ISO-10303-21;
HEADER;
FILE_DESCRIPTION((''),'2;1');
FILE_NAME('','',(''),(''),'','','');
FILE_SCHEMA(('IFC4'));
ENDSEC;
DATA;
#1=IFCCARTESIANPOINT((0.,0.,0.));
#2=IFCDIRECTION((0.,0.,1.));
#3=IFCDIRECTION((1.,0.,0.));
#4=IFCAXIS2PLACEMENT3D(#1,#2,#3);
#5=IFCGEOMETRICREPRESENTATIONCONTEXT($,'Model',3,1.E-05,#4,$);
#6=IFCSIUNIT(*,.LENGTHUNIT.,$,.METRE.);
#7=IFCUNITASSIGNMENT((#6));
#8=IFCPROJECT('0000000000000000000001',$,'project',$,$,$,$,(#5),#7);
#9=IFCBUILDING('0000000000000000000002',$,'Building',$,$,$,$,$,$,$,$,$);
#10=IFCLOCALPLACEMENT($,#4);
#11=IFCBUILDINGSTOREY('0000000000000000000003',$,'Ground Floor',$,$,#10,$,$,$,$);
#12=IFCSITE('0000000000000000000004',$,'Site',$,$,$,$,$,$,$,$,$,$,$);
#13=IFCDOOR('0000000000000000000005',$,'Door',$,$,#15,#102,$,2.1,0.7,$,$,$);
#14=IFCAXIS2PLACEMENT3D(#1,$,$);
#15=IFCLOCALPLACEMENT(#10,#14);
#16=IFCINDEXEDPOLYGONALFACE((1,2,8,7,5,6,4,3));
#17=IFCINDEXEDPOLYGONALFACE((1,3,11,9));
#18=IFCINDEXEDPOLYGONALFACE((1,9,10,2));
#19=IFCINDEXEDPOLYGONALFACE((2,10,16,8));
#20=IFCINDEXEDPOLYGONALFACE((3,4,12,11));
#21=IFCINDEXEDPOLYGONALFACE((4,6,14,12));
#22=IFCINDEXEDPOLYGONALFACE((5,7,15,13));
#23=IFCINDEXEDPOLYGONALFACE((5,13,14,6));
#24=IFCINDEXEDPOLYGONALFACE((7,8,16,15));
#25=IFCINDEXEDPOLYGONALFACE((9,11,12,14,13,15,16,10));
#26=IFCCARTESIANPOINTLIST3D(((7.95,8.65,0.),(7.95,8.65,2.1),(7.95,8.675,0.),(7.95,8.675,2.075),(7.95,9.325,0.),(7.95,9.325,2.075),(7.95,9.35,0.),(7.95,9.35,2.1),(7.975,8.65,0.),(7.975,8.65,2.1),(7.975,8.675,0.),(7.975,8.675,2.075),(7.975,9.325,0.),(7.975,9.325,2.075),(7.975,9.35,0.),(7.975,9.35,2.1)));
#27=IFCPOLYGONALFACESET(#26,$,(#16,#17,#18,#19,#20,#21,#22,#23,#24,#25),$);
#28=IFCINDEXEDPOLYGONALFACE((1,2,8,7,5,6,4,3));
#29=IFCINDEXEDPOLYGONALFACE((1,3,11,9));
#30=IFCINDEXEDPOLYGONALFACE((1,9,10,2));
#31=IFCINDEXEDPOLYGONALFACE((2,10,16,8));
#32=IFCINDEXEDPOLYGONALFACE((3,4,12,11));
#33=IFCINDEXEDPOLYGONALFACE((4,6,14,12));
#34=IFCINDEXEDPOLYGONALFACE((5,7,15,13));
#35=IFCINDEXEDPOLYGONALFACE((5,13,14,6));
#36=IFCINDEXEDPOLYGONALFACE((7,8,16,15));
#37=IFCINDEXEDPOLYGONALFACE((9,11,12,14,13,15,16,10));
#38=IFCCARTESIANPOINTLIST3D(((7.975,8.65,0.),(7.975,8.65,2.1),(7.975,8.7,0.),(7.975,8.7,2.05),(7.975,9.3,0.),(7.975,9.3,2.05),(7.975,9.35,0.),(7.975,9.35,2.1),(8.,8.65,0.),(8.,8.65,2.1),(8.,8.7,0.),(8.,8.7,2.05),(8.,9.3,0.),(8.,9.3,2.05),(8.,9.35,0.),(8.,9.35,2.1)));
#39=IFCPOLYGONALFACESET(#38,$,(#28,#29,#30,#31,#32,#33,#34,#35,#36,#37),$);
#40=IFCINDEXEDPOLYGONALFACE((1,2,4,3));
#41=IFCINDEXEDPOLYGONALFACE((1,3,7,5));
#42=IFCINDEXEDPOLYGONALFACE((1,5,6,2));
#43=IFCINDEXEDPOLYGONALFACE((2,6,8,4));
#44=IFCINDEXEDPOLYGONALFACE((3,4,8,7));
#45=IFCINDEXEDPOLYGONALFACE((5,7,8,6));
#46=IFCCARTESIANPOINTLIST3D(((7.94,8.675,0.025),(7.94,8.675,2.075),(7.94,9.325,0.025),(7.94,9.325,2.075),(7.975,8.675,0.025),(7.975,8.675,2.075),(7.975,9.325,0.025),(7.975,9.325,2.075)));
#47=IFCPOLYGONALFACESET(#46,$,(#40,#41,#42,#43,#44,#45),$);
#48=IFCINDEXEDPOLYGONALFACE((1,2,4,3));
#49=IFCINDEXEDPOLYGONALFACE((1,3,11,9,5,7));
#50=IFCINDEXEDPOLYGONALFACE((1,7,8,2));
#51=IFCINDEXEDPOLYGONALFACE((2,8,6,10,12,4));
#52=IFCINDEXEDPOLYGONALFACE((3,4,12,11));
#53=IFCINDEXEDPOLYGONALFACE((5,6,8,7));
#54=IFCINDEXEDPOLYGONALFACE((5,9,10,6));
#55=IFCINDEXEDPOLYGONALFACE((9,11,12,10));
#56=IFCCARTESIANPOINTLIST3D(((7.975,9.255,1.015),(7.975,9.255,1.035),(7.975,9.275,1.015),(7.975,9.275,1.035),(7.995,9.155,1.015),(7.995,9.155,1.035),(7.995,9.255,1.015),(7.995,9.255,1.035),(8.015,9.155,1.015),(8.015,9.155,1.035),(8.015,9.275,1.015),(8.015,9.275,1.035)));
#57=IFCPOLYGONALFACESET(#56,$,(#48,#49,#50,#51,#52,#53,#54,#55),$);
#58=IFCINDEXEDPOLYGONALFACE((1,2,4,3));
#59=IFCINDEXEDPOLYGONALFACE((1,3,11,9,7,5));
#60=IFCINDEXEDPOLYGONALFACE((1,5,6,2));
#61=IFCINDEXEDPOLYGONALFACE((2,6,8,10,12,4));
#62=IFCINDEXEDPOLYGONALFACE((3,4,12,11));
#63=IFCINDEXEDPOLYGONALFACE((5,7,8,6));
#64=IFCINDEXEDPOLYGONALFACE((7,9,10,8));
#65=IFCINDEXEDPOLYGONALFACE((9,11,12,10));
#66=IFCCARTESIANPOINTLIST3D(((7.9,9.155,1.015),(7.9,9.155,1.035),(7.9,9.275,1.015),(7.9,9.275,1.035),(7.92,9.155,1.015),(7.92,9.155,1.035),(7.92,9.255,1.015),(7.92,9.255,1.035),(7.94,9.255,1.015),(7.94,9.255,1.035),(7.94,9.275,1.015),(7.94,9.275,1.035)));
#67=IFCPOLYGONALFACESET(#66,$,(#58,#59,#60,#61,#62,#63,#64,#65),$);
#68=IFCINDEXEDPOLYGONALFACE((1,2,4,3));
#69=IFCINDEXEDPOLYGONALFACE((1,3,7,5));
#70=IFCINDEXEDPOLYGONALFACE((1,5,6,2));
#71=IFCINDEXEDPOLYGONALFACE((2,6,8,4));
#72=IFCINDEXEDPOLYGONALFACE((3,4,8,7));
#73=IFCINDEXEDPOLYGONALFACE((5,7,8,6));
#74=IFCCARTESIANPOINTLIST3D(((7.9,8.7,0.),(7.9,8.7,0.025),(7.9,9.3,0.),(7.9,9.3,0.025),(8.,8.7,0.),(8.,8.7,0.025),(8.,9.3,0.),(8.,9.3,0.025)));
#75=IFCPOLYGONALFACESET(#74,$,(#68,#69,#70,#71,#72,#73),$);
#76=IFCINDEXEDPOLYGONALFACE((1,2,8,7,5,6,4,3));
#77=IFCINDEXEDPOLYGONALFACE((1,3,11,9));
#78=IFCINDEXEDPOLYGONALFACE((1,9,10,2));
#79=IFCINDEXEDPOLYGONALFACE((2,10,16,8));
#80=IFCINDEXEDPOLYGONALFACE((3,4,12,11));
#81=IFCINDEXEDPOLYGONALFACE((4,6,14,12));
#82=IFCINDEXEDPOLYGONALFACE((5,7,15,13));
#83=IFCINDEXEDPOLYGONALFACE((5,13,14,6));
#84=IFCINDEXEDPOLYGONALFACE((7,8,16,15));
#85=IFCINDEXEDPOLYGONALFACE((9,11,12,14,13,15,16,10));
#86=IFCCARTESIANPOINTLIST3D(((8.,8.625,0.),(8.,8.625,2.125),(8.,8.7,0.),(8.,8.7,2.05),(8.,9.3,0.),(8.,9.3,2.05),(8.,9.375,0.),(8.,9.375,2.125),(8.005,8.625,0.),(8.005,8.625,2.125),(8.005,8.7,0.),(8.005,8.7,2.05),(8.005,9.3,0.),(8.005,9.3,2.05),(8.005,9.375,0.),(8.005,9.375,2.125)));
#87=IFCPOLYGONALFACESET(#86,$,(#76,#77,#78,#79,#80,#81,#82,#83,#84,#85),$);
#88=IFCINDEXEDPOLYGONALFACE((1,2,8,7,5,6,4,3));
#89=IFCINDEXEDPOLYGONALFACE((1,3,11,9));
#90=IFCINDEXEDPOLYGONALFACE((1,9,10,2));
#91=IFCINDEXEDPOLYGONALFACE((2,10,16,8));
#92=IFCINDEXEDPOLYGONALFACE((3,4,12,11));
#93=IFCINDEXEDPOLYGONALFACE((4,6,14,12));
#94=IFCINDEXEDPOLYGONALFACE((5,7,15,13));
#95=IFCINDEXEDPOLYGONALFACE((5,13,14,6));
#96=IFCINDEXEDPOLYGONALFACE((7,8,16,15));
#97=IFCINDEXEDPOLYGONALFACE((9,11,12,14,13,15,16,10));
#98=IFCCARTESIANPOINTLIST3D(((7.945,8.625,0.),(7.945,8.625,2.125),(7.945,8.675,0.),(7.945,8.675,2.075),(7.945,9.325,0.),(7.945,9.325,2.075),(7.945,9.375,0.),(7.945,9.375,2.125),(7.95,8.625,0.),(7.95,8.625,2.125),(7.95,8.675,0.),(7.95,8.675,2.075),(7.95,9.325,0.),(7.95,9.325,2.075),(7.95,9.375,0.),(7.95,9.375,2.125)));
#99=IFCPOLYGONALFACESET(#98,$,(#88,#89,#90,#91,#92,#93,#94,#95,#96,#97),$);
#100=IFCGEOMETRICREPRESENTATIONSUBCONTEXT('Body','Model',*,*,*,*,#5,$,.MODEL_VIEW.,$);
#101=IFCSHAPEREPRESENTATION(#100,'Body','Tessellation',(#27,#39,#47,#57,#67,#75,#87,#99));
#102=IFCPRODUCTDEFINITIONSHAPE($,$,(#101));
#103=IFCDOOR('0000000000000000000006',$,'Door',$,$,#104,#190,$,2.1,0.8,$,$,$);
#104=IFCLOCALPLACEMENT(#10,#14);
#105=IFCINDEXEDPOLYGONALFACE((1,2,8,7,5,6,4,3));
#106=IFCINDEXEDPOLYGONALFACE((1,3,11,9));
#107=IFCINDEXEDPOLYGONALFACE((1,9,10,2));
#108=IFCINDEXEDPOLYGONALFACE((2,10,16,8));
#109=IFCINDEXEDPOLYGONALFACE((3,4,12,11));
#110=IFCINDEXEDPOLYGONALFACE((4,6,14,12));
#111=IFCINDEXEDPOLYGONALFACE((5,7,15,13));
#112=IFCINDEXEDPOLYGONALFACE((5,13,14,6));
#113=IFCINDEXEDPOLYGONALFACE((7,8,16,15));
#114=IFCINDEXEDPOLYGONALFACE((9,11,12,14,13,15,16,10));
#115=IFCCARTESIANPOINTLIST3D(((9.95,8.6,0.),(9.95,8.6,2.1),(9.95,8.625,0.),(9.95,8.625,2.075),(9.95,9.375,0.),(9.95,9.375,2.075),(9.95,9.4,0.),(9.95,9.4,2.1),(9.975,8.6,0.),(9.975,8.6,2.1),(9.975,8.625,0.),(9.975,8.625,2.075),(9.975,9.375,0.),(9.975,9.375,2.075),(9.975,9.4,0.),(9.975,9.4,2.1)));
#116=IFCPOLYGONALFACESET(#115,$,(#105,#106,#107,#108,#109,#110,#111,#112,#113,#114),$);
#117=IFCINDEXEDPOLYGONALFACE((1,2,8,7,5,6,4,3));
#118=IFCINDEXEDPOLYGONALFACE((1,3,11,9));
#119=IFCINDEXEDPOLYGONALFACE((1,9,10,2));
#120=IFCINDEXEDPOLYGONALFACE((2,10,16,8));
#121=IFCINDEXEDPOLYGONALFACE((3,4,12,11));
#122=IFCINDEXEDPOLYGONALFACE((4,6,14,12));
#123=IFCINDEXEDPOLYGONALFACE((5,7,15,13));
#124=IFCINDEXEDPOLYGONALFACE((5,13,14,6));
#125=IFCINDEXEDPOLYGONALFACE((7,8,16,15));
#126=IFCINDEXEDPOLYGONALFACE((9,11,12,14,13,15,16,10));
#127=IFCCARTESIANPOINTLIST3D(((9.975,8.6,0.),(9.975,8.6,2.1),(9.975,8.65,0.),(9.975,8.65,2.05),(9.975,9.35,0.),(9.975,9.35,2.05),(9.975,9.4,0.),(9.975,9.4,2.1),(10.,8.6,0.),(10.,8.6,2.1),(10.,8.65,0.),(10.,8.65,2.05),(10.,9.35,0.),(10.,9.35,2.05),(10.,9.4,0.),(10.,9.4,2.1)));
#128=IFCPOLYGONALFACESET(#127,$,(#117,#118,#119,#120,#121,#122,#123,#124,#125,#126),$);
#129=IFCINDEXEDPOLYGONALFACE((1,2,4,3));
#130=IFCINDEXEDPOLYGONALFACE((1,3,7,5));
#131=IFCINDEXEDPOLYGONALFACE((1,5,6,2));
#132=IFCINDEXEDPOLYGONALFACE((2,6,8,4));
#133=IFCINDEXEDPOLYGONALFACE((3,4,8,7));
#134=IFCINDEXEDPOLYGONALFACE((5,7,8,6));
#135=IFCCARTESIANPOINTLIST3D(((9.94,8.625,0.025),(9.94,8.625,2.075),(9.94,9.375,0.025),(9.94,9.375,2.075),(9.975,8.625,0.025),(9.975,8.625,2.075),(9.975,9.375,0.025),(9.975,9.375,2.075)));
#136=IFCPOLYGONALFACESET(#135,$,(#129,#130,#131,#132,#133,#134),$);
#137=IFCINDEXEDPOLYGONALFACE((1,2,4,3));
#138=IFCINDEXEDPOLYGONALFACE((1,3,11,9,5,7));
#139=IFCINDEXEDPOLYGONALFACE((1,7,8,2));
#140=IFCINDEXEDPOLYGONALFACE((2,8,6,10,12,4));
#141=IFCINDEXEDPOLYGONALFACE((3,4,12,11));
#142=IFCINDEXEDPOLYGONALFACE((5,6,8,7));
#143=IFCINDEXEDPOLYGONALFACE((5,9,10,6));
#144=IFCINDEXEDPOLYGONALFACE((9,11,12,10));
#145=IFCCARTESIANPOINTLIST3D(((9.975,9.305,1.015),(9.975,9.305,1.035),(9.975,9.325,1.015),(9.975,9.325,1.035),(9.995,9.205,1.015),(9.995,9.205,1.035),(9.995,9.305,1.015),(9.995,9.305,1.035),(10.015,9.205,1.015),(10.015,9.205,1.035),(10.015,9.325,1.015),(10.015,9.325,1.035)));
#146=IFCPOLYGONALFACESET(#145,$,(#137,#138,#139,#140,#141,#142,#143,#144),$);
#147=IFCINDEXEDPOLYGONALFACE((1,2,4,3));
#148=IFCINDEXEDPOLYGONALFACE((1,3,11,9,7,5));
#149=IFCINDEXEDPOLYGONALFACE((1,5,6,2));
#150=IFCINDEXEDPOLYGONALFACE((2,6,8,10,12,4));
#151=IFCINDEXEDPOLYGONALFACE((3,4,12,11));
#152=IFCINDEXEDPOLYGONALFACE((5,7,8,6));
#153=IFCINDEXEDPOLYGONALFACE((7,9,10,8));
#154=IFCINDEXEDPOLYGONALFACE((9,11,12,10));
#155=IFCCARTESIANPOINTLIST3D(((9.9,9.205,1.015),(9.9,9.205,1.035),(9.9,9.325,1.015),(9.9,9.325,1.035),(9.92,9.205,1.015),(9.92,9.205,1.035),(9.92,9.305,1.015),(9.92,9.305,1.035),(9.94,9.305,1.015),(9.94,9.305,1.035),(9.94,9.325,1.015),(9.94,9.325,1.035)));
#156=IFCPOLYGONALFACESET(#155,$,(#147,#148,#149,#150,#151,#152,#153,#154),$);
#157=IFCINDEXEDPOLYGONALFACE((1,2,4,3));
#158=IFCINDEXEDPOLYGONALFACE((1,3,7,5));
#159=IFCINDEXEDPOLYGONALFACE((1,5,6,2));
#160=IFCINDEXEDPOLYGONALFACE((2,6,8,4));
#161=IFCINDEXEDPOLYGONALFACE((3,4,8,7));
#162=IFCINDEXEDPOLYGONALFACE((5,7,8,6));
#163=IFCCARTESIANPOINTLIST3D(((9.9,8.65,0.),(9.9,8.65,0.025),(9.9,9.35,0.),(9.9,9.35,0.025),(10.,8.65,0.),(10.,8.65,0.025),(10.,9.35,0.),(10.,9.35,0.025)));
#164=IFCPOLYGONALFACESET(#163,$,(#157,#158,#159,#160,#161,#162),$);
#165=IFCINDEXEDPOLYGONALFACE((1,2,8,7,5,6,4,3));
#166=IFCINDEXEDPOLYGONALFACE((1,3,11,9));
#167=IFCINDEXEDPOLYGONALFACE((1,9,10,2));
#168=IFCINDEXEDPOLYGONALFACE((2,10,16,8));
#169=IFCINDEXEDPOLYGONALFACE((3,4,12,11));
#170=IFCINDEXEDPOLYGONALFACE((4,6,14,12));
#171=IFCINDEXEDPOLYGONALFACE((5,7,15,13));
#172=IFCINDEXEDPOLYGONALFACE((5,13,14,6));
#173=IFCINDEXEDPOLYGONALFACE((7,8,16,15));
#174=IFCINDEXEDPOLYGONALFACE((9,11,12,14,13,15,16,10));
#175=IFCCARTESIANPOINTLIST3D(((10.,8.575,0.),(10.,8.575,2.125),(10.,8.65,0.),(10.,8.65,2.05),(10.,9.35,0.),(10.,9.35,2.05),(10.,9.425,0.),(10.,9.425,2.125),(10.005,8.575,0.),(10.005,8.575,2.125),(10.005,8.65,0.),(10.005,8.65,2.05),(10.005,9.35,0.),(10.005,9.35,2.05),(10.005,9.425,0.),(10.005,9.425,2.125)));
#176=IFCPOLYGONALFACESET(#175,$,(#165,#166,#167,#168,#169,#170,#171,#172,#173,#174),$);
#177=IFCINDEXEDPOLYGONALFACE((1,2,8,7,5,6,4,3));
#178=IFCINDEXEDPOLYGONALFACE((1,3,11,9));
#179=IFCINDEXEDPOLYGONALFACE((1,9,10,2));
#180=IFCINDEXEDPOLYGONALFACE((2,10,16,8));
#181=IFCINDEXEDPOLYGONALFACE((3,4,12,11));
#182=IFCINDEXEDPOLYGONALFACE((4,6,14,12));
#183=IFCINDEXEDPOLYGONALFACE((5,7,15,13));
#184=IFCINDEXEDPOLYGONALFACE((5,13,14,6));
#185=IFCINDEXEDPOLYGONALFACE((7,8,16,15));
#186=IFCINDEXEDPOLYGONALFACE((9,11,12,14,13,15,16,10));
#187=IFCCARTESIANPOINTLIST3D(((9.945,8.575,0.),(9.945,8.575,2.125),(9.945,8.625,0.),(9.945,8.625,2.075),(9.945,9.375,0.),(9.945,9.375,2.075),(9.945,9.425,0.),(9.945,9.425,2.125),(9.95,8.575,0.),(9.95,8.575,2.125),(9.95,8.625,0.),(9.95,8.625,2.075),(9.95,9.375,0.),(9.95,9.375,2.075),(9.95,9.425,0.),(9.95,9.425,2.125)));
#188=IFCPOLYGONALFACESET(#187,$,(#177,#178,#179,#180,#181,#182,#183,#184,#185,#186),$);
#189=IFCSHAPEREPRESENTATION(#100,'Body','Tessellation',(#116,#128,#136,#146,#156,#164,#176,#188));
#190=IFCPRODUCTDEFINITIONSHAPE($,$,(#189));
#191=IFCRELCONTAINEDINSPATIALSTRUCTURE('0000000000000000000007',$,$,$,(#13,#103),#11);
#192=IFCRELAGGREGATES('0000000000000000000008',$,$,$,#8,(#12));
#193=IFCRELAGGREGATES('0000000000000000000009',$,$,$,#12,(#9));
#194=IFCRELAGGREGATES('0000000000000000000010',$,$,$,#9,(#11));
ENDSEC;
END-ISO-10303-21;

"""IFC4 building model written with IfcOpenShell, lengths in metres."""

from ifc_helpers import new_model, si_unit, frame, origin_with_axes, place, context, subcontext, project, spatial, line, indexed_curve, outline, extrude, element, save


model = new_model("IFC4")

# Units and contexts
model_context = context("Model", 3, precision=1e-05, world=origin_with_axes())
body_context = subcontext(model_context, "Body", "Model", "MODEL_VIEW")
ifc_project = project(units=[si_unit("LENGTHUNIT", "METRE")], contexts=[model_context])

# Site, building, storey
site = spatial("IfcSite", under=ifc_project, Name="Site")
building = spatial("IfcBuilding", under=site, Name="Building")
storey_placement = place(None, origin_with_axes())
storey = spatial("IfcBuildingStorey", under=building, at=storey_placement, Name="Ground Floor")

# Doors
door_1_placement = place(storey_placement, frame((8.0, 8.65, 0.0), z_axis=(0.0, 0.0, 1.0), x_axis=(0.0, 1.0, 0.0)))
element("IfcDoor", 1, at=door_1_placement, inside=storey, Name="Door", OverallHeight=2.1, OverallWidth=0.7, context=body_context, shape_type="SweptSolid", body=[
    extrude(outline(indexed_curve([(0.0, 0.0), (0.0, 2.1), (0.7, 2.1), (0.7, 0.0), (0.675, 0.0), (0.675, 2.075), (0.025, 2.075), (0.025, 0.0)], segments=[line(1, 2, 3, 4, 5, 6, 7, 8, 1)])), frame((0.0, 0.025, 0.0), z_axis=(0.0, -1.0, 0.0), x_axis=(1.0, 0.0, 0.0)), (0.0, 0.0, -1.0), 0.025),
    extrude(outline(indexed_curve([(0.0, 0.0), (0.0, 2.1), (0.7, 2.1), (0.7, 0.0), (0.65, 0.0), (0.65, 2.05), (0.05, 2.05), (0.05, 0.0)], segments=[line(1, 2, 3, 4, 5, 6, 7, 8, 1)])), frame((0.0, 0.0, 0.0), z_axis=(0.0, -1.0, 0.0), x_axis=(1.0, 0.0, 0.0)), (0.0, 0.0, -1.0), 0.025),
    extrude(outline(indexed_curve([(0.0, 0.0), (0.65, 0.0), (0.65, 0.035), (0.0, 0.035)], segments=[line(1, 2, 3, 4, 1)])), frame((0.025, 0.025, 0.025), z_axis=(0.0, 0.0, 1.0), x_axis=(1.0, 0.0, 0.0)), (0.0, 0.0, 1.0), 2.05),
    extrude(outline(indexed_curve([(0.0, 0.0), (0.0, -0.04), (-0.12, -0.04), (-0.12, -0.02), (-0.02, -0.02), (-0.02, 0.0)], segments=[line(1, 2, 3, 4, 5, 6, 1)])), frame((0.625, 0.025, 1.015), z_axis=(0.0, 0.0, 1.0), x_axis=(1.0, 0.0, 0.0)), (0.0, 0.0, 1.0), 0.02),
    extrude(outline(indexed_curve([(0.0, 0.0), (0.0, 0.04), (-0.12, 0.04), (-0.12, 0.02), (-0.02, 0.02), (-0.02, 0.0)], segments=[line(1, 2, 3, 4, 5, 6, 1)])), frame((0.625, 0.06, 1.015), z_axis=(0.0, 0.0, 1.0), x_axis=(1.0, 0.0, 0.0)), (0.0, 0.0, 1.0), 0.02),
    extrude(outline(indexed_curve([(0.0, 0.0), (0.6, 0.0), (0.6, 0.1), (0.0, 0.1)], segments=[line(1, 2, 3, 4, 1)])), frame((0.05, 0.0, 0.0), z_axis=(0.0, 0.0, 1.0), x_axis=(1.0, 0.0, 0.0)), (0.0, 0.0, 1.0), 0.025),
    extrude(outline(indexed_curve([(0.0, 0.0), (0.0, 2.125), (0.75, 2.125), (0.75, 0.0), (0.675, 0.0), (0.675, 2.05), (0.075, 2.05), (0.075, 0.0)], segments=[line(1, 2, 3, 4, 5, 6, 7, 8, 1)])), frame((-0.025, -0.005, 0.0), z_axis=(0.0, -1.0, 0.0), x_axis=(1.0, 0.0, 0.0)), (0.0, 0.0, -1.0), 0.005),
    extrude(outline(indexed_curve([(0.0, 0.0), (0.0, 2.125), (0.75, 2.125), (0.75, 0.0), (0.7, 0.0), (0.7, 2.075), (0.05, 2.075), (0.05, 0.0)], segments=[line(1, 2, 3, 4, 5, 6, 7, 8, 1)])), frame((-0.025, 0.05, 0.0), z_axis=(0.0, -1.0, 0.0), x_axis=(1.0, 0.0, 0.0)), (0.0, 0.0, -1.0), 0.005),
])
door_2_placement = place(storey_placement, frame((10.0, 8.6, 0.0), z_axis=(0.0, 0.0, 1.0), x_axis=(0.0, 1.0, 0.0)))
element("IfcDoor", 2, at=door_2_placement, inside=storey, Name="Door", OverallHeight=2.1, OverallWidth=0.8, context=body_context, shape_type="SweptSolid", body=[
    extrude(outline(indexed_curve([(0.0, 0.0), (0.0, 2.1), (0.8, 2.1), (0.8, 0.0), (0.775, 0.0), (0.775, 2.075), (0.025, 2.075), (0.025, 0.0)], segments=[line(1, 2, 3, 4, 5, 6, 7, 8, 1)])), frame((0.0, 0.025, 0.0), z_axis=(0.0, -1.0, 0.0), x_axis=(1.0, 0.0, 0.0)), (0.0, 0.0, -1.0), 0.025),
    extrude(outline(indexed_curve([(0.0, 0.0), (0.0, 2.1), (0.8, 2.1), (0.8, 0.0), (0.75, 0.0), (0.75, 2.05), (0.05, 2.05), (0.05, 0.0)], segments=[line(1, 2, 3, 4, 5, 6, 7, 8, 1)])), frame((0.0, 0.0, 0.0), z_axis=(0.0, -1.0, 0.0), x_axis=(1.0, 0.0, 0.0)), (0.0, 0.0, -1.0), 0.025),
    extrude(outline(indexed_curve([(0.0, 0.0), (0.75, 0.0), (0.75, 0.035), (0.0, 0.035)], segments=[line(1, 2, 3, 4, 1)])), frame((0.025, 0.025, 0.025), z_axis=(0.0, 0.0, 1.0), x_axis=(1.0, 0.0, 0.0)), (0.0, 0.0, 1.0), 2.05),
    extrude(outline(indexed_curve([(0.0, 0.0), (0.0, -0.04), (-0.12, -0.04), (-0.12, -0.02), (-0.02, -0.02), (-0.02, 0.0)], segments=[line(1, 2, 3, 4, 5, 6, 1)])), frame((0.725, 0.025, 1.015), z_axis=(0.0, 0.0, 1.0), x_axis=(1.0, 0.0, 0.0)), (0.0, 0.0, 1.0), 0.02),
    extrude(outline(indexed_curve([(0.0, 0.0), (0.0, 0.04), (-0.12, 0.04), (-0.12, 0.02), (-0.02, 0.02), (-0.02, 0.0)], segments=[line(1, 2, 3, 4, 5, 6, 1)])), frame((0.725, 0.06, 1.015), z_axis=(0.0, 0.0, 1.0), x_axis=(1.0, 0.0, 0.0)), (0.0, 0.0, 1.0), 0.02),
    extrude(outline(indexed_curve([(0.0, 0.0), (0.7, 0.0), (0.7, 0.1), (0.0, 0.1)], segments=[line(1, 2, 3, 4, 1)])), frame((0.05, 0.0, 0.0), z_axis=(0.0, 0.0, 1.0), x_axis=(1.0, 0.0, 0.0)), (0.0, 0.0, 1.0), 0.025),
    extrude(outline(indexed_curve([(0.0, 0.0), (0.0, 2.125), (0.85, 2.125), (0.85, 0.0), (0.775, 0.0), (0.775, 2.05), (0.075, 2.05), (0.075, 0.0)], segments=[line(1, 2, 3, 4, 5, 6, 7, 8, 1)])), frame((-0.025, -0.005, 0.0), z_axis=(0.0, -1.0, 0.0), x_axis=(1.0, 0.0, 0.0)), (0.0, 0.0, -1.0), 0.005),
    extrude(outline(indexed_curve([(0.0, 0.0), (0.0, 2.125), (0.85, 2.125), (0.85, 0.0), (0.8, 0.0), (0.8, 2.075), (0.05, 2.075), (0.05, 0.0)], segments=[line(1, 2, 3, 4, 5, 6, 7, 8, 1)])), frame((-0.025, 0.05, 0.0), z_axis=(0.0, -1.0, 0.0), x_axis=(1.0, 0.0, 0.0)), (0.0, 0.0, -1.0), 0.005),
])

save(model, "model.ifc")
